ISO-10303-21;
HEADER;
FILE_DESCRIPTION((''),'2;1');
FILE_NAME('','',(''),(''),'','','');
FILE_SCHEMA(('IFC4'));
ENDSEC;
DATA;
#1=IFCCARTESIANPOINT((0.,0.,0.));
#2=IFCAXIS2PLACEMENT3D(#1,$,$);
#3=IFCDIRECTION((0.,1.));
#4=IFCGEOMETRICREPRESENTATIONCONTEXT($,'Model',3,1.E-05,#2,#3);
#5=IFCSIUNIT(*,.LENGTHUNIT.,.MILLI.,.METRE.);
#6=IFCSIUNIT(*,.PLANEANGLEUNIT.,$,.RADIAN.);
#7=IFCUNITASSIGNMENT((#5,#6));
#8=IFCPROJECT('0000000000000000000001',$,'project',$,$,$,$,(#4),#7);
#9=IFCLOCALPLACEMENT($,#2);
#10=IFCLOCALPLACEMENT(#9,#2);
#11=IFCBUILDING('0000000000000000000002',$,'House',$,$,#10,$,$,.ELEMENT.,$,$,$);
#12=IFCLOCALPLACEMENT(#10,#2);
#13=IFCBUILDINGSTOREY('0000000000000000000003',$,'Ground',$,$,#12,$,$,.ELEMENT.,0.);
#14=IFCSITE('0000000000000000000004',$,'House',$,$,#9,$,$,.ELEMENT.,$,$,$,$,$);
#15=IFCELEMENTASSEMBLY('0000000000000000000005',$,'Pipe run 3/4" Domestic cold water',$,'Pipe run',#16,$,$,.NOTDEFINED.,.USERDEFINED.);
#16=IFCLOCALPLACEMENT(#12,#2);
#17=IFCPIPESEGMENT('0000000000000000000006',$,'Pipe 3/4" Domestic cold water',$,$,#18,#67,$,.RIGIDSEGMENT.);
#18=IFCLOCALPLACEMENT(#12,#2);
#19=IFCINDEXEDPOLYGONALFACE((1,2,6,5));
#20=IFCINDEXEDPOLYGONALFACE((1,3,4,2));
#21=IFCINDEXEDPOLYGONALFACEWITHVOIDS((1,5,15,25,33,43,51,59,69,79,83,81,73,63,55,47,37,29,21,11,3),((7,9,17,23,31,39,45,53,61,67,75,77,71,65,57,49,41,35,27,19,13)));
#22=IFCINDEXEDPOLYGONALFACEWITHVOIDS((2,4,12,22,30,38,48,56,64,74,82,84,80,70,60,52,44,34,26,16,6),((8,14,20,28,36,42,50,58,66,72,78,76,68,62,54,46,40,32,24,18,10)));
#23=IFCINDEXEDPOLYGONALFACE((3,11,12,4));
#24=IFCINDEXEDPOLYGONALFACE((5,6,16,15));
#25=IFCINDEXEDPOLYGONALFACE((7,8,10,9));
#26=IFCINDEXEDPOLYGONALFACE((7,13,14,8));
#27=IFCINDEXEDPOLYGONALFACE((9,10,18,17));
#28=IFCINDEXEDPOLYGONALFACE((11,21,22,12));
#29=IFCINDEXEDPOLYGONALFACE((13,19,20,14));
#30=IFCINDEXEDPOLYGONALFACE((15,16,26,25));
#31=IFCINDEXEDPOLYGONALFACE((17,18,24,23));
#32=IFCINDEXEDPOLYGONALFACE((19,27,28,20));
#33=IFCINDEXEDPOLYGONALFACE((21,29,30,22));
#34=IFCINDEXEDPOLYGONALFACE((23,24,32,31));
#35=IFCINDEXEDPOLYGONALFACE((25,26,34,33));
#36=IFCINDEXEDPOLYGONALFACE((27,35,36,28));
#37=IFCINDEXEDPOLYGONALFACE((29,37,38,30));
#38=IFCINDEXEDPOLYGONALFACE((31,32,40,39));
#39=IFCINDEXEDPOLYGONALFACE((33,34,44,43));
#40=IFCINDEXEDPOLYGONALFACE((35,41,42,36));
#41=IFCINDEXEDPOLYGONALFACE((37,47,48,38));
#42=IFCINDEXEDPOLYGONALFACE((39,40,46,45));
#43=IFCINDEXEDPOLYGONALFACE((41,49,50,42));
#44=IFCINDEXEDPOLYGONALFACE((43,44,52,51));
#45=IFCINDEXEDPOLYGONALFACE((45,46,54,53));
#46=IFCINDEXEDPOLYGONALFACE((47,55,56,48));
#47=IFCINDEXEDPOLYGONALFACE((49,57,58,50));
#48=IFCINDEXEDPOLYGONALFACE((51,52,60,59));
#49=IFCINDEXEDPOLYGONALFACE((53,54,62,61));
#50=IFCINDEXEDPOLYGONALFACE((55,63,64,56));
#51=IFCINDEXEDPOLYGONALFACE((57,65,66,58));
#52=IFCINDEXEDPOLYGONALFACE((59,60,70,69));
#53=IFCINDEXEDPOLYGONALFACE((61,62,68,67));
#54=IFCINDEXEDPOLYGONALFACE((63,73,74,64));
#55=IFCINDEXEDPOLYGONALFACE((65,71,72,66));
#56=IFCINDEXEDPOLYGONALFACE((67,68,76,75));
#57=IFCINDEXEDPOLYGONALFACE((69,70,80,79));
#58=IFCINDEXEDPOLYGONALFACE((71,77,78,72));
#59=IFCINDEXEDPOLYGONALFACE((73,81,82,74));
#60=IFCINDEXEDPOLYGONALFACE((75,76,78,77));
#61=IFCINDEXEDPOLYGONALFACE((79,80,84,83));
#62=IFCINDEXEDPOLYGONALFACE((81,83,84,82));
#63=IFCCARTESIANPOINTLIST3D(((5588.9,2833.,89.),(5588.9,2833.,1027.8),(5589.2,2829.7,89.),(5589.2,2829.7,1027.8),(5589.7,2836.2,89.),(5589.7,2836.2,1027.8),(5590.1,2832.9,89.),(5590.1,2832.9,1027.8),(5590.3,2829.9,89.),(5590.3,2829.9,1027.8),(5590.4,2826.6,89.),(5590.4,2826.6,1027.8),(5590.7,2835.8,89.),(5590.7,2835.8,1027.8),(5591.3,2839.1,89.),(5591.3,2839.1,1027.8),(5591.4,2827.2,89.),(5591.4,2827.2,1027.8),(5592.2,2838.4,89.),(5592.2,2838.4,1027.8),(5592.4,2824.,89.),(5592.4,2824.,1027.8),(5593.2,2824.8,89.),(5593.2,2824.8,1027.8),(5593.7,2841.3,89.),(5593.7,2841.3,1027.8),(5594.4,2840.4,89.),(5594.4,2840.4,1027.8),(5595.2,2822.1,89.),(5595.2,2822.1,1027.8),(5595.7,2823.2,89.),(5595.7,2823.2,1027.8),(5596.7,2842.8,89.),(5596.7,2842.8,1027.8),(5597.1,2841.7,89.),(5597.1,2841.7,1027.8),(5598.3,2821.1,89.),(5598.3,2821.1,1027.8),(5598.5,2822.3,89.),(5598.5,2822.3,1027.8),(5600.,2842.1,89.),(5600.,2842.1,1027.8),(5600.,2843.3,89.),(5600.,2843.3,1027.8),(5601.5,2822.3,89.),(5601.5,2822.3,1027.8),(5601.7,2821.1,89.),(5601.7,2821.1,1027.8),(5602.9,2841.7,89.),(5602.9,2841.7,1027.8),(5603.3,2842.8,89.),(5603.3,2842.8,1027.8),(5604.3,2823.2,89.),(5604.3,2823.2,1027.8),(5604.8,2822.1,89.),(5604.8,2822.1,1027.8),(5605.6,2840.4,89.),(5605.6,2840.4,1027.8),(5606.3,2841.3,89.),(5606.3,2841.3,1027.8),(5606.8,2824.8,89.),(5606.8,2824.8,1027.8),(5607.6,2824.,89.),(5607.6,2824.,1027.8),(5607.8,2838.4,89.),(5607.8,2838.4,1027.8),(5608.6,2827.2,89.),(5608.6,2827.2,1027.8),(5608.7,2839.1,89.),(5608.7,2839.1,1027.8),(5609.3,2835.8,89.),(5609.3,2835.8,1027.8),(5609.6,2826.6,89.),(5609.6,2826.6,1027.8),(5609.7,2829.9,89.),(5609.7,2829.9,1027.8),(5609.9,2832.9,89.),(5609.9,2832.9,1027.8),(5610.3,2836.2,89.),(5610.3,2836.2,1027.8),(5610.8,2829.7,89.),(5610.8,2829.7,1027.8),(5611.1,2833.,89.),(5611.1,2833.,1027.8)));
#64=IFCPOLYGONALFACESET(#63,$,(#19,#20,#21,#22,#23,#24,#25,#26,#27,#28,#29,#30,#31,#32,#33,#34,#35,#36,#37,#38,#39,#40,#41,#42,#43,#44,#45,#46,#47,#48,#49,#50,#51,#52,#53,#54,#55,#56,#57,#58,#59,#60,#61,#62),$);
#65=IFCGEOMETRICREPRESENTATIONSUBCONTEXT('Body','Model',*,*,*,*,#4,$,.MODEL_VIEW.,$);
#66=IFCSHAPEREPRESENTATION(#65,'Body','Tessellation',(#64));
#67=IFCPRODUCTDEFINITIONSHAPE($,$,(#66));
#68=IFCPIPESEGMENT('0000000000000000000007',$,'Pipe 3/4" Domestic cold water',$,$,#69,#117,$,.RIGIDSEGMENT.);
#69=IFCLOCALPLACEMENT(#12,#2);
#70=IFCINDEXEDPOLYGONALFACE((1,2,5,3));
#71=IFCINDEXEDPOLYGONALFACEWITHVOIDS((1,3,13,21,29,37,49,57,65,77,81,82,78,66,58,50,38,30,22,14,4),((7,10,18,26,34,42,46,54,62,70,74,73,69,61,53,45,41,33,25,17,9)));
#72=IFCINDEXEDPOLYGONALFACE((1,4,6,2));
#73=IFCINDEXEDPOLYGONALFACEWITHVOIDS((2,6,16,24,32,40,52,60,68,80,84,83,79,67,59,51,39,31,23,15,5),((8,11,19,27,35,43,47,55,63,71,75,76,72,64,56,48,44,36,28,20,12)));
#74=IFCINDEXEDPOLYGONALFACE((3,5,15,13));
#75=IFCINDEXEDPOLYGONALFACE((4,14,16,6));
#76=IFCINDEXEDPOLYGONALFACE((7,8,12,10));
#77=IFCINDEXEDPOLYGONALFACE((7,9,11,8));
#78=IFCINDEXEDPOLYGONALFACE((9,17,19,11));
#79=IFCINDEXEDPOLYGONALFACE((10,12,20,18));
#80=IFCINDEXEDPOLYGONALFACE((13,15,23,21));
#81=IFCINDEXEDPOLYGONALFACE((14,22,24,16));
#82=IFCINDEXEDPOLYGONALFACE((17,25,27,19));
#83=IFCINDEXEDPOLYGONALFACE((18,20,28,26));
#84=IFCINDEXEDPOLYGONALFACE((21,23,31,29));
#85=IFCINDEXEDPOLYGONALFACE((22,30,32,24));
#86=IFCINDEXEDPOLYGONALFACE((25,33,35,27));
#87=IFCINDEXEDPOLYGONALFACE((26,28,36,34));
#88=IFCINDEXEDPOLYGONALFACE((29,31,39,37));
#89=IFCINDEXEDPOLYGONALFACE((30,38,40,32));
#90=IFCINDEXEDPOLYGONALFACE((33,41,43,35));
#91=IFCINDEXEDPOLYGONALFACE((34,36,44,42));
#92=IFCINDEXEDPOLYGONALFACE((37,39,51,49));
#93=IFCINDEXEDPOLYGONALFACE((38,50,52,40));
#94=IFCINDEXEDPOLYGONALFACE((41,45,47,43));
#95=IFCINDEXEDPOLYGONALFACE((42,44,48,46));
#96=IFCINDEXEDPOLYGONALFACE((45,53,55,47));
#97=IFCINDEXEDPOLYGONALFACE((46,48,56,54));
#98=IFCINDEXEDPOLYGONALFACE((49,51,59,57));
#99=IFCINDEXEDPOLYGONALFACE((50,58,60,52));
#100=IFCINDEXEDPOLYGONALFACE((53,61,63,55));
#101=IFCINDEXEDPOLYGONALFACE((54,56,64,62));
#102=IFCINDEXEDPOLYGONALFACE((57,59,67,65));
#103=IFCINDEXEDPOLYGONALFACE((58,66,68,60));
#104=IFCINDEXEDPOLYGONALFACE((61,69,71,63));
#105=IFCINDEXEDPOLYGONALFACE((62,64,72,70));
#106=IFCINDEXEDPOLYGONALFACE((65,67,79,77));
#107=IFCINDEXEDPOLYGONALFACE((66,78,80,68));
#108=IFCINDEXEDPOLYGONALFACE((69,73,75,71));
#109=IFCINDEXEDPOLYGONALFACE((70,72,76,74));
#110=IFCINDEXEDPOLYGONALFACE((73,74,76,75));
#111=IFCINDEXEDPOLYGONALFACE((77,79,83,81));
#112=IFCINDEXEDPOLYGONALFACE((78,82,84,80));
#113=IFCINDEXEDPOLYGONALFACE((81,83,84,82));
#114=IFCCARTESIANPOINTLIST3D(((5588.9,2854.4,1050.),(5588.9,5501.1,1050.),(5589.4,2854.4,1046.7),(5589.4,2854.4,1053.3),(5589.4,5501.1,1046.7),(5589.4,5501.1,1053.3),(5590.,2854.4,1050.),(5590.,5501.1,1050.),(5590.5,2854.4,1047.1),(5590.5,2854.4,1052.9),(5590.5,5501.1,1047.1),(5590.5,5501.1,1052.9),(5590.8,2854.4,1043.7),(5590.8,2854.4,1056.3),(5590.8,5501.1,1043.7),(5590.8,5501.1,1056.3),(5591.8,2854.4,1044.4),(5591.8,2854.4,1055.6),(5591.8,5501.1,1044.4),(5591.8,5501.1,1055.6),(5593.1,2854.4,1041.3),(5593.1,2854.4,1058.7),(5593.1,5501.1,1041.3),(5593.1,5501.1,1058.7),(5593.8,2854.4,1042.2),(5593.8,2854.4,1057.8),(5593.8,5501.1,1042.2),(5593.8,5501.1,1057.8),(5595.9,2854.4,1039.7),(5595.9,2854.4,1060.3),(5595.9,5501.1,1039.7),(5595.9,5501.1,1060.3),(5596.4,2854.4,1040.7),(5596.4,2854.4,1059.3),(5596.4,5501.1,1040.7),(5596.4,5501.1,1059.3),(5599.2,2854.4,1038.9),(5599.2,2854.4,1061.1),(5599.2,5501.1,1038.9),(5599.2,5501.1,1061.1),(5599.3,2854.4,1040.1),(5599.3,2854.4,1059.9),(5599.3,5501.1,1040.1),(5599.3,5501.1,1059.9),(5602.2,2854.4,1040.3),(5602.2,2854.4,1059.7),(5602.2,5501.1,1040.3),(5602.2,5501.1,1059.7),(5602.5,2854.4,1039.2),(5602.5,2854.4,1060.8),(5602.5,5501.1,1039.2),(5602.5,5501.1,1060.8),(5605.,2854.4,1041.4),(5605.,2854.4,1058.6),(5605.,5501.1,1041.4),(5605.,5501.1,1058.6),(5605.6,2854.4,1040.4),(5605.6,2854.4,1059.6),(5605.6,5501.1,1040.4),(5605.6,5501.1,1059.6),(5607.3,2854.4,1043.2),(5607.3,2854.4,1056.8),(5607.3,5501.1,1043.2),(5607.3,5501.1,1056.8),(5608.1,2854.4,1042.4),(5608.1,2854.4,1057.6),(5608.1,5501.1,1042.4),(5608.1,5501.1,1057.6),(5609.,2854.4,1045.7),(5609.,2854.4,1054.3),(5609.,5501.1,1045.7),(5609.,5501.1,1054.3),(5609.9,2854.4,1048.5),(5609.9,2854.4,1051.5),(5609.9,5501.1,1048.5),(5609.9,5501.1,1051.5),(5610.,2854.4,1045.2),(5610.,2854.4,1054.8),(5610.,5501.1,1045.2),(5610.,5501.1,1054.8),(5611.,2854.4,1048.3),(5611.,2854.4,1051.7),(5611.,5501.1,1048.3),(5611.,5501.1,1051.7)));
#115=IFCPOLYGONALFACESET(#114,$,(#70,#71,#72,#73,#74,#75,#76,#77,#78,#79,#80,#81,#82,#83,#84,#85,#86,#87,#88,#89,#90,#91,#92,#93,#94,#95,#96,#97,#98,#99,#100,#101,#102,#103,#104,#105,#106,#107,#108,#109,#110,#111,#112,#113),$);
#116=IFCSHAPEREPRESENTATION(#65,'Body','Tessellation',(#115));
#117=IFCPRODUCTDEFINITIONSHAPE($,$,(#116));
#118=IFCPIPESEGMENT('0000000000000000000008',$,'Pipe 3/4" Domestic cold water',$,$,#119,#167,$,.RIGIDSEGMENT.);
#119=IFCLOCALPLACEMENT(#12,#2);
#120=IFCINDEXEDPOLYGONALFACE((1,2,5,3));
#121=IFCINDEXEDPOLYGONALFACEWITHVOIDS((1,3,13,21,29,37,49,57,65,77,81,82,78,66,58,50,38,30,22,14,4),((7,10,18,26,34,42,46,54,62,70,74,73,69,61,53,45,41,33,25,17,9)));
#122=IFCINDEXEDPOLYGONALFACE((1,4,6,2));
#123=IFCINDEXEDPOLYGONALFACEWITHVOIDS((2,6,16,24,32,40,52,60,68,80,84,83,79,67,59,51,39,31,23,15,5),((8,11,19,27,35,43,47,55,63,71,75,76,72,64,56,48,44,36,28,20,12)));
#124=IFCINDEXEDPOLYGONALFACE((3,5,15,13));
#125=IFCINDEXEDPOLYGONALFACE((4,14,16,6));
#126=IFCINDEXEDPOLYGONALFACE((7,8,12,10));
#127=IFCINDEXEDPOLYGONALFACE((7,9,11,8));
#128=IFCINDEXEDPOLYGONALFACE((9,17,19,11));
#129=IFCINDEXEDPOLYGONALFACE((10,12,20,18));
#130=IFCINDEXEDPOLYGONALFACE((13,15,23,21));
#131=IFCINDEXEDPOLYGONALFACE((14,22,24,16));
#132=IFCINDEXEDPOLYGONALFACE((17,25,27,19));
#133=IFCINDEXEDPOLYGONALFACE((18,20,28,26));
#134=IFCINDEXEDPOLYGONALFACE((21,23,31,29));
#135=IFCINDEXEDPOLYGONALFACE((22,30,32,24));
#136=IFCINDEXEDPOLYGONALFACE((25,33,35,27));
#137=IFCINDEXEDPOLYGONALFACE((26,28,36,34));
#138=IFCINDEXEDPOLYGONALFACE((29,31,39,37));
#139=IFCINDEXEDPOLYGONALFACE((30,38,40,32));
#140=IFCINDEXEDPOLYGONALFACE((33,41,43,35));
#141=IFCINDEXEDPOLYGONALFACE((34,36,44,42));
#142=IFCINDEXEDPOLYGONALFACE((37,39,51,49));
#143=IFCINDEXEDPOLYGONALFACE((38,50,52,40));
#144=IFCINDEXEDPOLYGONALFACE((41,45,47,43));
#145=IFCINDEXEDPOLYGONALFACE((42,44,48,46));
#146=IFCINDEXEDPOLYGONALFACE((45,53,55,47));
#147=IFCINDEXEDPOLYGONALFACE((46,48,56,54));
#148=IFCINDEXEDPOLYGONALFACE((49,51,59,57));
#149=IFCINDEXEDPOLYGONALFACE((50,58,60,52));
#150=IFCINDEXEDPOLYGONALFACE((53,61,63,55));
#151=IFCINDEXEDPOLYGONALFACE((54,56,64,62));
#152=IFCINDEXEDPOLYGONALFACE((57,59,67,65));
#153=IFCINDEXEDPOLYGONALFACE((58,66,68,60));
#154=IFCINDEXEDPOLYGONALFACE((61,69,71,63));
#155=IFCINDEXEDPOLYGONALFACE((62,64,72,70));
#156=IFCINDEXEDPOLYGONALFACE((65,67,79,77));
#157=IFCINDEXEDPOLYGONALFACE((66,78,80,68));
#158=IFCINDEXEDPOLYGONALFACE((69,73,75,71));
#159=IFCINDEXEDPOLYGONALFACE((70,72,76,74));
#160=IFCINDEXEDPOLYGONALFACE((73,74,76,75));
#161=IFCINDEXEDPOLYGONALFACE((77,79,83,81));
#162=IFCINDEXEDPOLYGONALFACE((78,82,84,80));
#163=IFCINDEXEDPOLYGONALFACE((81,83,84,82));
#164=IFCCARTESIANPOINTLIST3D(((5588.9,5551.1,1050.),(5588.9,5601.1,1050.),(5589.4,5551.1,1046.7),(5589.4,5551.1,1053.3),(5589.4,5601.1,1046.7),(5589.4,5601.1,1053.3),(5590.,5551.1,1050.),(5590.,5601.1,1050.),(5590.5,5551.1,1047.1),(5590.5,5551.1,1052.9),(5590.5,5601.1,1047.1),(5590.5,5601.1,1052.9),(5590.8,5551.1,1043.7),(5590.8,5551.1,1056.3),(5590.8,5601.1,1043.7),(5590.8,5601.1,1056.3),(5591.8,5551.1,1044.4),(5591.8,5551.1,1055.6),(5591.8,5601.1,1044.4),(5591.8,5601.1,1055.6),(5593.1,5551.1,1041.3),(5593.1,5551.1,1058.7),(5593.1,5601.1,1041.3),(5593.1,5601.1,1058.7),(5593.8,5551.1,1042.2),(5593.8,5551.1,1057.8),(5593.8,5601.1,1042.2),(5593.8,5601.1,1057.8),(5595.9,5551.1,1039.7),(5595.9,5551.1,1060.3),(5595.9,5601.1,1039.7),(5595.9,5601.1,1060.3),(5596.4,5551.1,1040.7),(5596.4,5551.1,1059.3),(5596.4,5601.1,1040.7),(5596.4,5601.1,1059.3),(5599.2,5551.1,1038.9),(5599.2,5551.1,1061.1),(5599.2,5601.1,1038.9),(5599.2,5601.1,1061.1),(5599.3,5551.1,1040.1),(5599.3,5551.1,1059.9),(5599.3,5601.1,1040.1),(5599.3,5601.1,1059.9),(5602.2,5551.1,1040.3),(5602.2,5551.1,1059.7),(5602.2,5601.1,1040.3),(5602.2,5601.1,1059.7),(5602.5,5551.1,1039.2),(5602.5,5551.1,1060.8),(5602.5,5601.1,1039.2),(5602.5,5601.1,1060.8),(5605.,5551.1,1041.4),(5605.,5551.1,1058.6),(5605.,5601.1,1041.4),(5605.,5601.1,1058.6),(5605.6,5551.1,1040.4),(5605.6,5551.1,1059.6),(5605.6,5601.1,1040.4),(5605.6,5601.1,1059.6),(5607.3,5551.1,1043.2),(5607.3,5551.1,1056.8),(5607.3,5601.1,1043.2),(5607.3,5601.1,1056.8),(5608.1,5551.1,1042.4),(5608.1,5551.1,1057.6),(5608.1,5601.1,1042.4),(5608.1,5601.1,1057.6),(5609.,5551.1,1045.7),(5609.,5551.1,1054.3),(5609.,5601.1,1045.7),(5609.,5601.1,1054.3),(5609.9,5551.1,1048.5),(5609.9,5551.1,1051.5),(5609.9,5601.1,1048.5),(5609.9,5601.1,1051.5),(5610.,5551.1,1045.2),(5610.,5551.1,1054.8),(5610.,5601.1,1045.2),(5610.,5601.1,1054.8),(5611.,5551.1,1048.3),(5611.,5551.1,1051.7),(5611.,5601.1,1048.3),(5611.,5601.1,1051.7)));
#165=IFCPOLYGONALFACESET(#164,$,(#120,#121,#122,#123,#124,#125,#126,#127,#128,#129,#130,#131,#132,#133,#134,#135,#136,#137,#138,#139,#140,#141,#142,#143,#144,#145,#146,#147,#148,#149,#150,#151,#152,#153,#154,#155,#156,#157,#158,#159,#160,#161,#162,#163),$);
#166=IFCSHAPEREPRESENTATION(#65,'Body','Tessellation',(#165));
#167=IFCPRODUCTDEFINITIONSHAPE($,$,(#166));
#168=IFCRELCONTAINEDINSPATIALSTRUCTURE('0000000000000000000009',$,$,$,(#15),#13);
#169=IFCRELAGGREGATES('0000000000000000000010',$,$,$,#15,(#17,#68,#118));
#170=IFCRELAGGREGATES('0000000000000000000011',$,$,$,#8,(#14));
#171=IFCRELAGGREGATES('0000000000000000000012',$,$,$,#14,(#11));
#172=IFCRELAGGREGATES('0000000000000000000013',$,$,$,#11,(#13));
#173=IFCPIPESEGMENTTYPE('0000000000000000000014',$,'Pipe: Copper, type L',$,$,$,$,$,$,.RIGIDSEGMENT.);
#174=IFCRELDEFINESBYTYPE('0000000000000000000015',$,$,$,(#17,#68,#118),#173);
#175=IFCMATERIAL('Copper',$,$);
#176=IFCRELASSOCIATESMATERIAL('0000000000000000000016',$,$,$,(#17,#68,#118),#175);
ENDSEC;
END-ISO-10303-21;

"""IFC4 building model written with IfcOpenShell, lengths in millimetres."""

from ifc_helpers import new_model, si_unit, direction, frame, origin, origin_with_axes, origin_2d, place, context, subcontext, project, spatial, hollow_circle, extrude, material, type_object, element, aggregate, save


model = new_model("IFC4")

# Units and contexts
model_context = context("Model", 3, precision=1e-05, world=origin(), true_north=direction((0.0, 1.0)))
body_context = subcontext(model_context, "Body", "Model", "MODEL_VIEW")
ifc_project = project(units=[si_unit("LENGTHUNIT", "METRE", prefix="MILLI"), si_unit("PLANEANGLEUNIT", "RADIAN")], contexts=[model_context])

# Site, building, storey
site_placement = place(None, origin())
site = spatial("IfcSite", under=ifc_project, at=site_placement, Name="House", CompositionType="ELEMENT")
building_placement = place(site_placement, origin())
building = spatial("IfcBuilding", under=site, at=building_placement, Name="House", CompositionType="ELEMENT")
storey_placement = place(building_placement, origin())
storey = spatial("IfcBuildingStorey", under=building, at=storey_placement, Name="Ground", CompositionType="ELEMENT", Elevation=0.0)

# Element assembly, pipe segments
ifc_material = material(Name="Copper")
pipe_segment_type = type_object("IfcPipeSegmentType", Name="Pipe: Copper, type L", PredefinedType="RIGIDSEGMENT")
assembly_1_placement = place(storey_placement, origin_with_axes())
assembly_1 = element("IfcElementAssembly", 1, at=assembly_1_placement, inside=storey, Name="Pipe run 3/4\" Domestic cold water", ObjectType="Pipe run", AssemblyPlace="NOTDEFINED", PredefinedType="USERDEFINED")
pipe_segment_1_placement = place(storey_placement, origin_with_axes())
pipe_segment_1 = element("IfcPipeSegment", 2, at=pipe_segment_1_placement, type_object=pipe_segment_type, material=ifc_material, Name="Pipe 3/4\" Domestic cold water", PredefinedType="RIGIDSEGMENT", context=body_context, shape_type="SweptSolid", body=[
    extrude(hollow_circle(Radius=11.1, WallThickness=1.1, at=origin_2d()), frame((5600.0, 2832.1, 89.0), z_axis=(0.0, 0.0, 1.0), x_axis=(0.0, 1.0, 0.0)), (0.0, 0.0, 1.0), 938.7),
])
pipe_segment_2_placement = place(storey_placement, origin_with_axes())
pipe_segment_2 = element("IfcPipeSegment", 3, at=pipe_segment_2_placement, type_object=pipe_segment_type, material=ifc_material, Name="Pipe 3/4\" Domestic cold water", PredefinedType="RIGIDSEGMENT", context=body_context, shape_type="SweptSolid", body=[
    extrude(hollow_circle(Radius=11.1, WallThickness=1.1, at=origin_2d()), frame((5600.0, 2854.4, 1050.0), z_axis=(0.0, 1.0, 0.0), x_axis=(-1.0, 0.0, 0.0)), (0.0, 0.0, 1.0), 2646.8),
])
pipe_segment_3_placement = place(storey_placement, origin_with_axes())
pipe_segment_3 = element("IfcPipeSegment", 4, at=pipe_segment_3_placement, type_object=pipe_segment_type, material=ifc_material, Name="Pipe 3/4\" Domestic cold water", PredefinedType="RIGIDSEGMENT", context=body_context, shape_type="SweptSolid", body=[
    extrude(hollow_circle(Radius=11.1, WallThickness=1.1, at=origin_2d()), frame((5600.0, 5551.1, 1050.0), z_axis=(0.0, 1.0, 0.0), x_axis=(-1.0, 0.0, 0.0)), (0.0, 0.0, 1.0), 50.0),
])

aggregate(assembly_1, [pipe_segment_1, pipe_segment_2, pipe_segment_3])

save(model, "model.ifc")
